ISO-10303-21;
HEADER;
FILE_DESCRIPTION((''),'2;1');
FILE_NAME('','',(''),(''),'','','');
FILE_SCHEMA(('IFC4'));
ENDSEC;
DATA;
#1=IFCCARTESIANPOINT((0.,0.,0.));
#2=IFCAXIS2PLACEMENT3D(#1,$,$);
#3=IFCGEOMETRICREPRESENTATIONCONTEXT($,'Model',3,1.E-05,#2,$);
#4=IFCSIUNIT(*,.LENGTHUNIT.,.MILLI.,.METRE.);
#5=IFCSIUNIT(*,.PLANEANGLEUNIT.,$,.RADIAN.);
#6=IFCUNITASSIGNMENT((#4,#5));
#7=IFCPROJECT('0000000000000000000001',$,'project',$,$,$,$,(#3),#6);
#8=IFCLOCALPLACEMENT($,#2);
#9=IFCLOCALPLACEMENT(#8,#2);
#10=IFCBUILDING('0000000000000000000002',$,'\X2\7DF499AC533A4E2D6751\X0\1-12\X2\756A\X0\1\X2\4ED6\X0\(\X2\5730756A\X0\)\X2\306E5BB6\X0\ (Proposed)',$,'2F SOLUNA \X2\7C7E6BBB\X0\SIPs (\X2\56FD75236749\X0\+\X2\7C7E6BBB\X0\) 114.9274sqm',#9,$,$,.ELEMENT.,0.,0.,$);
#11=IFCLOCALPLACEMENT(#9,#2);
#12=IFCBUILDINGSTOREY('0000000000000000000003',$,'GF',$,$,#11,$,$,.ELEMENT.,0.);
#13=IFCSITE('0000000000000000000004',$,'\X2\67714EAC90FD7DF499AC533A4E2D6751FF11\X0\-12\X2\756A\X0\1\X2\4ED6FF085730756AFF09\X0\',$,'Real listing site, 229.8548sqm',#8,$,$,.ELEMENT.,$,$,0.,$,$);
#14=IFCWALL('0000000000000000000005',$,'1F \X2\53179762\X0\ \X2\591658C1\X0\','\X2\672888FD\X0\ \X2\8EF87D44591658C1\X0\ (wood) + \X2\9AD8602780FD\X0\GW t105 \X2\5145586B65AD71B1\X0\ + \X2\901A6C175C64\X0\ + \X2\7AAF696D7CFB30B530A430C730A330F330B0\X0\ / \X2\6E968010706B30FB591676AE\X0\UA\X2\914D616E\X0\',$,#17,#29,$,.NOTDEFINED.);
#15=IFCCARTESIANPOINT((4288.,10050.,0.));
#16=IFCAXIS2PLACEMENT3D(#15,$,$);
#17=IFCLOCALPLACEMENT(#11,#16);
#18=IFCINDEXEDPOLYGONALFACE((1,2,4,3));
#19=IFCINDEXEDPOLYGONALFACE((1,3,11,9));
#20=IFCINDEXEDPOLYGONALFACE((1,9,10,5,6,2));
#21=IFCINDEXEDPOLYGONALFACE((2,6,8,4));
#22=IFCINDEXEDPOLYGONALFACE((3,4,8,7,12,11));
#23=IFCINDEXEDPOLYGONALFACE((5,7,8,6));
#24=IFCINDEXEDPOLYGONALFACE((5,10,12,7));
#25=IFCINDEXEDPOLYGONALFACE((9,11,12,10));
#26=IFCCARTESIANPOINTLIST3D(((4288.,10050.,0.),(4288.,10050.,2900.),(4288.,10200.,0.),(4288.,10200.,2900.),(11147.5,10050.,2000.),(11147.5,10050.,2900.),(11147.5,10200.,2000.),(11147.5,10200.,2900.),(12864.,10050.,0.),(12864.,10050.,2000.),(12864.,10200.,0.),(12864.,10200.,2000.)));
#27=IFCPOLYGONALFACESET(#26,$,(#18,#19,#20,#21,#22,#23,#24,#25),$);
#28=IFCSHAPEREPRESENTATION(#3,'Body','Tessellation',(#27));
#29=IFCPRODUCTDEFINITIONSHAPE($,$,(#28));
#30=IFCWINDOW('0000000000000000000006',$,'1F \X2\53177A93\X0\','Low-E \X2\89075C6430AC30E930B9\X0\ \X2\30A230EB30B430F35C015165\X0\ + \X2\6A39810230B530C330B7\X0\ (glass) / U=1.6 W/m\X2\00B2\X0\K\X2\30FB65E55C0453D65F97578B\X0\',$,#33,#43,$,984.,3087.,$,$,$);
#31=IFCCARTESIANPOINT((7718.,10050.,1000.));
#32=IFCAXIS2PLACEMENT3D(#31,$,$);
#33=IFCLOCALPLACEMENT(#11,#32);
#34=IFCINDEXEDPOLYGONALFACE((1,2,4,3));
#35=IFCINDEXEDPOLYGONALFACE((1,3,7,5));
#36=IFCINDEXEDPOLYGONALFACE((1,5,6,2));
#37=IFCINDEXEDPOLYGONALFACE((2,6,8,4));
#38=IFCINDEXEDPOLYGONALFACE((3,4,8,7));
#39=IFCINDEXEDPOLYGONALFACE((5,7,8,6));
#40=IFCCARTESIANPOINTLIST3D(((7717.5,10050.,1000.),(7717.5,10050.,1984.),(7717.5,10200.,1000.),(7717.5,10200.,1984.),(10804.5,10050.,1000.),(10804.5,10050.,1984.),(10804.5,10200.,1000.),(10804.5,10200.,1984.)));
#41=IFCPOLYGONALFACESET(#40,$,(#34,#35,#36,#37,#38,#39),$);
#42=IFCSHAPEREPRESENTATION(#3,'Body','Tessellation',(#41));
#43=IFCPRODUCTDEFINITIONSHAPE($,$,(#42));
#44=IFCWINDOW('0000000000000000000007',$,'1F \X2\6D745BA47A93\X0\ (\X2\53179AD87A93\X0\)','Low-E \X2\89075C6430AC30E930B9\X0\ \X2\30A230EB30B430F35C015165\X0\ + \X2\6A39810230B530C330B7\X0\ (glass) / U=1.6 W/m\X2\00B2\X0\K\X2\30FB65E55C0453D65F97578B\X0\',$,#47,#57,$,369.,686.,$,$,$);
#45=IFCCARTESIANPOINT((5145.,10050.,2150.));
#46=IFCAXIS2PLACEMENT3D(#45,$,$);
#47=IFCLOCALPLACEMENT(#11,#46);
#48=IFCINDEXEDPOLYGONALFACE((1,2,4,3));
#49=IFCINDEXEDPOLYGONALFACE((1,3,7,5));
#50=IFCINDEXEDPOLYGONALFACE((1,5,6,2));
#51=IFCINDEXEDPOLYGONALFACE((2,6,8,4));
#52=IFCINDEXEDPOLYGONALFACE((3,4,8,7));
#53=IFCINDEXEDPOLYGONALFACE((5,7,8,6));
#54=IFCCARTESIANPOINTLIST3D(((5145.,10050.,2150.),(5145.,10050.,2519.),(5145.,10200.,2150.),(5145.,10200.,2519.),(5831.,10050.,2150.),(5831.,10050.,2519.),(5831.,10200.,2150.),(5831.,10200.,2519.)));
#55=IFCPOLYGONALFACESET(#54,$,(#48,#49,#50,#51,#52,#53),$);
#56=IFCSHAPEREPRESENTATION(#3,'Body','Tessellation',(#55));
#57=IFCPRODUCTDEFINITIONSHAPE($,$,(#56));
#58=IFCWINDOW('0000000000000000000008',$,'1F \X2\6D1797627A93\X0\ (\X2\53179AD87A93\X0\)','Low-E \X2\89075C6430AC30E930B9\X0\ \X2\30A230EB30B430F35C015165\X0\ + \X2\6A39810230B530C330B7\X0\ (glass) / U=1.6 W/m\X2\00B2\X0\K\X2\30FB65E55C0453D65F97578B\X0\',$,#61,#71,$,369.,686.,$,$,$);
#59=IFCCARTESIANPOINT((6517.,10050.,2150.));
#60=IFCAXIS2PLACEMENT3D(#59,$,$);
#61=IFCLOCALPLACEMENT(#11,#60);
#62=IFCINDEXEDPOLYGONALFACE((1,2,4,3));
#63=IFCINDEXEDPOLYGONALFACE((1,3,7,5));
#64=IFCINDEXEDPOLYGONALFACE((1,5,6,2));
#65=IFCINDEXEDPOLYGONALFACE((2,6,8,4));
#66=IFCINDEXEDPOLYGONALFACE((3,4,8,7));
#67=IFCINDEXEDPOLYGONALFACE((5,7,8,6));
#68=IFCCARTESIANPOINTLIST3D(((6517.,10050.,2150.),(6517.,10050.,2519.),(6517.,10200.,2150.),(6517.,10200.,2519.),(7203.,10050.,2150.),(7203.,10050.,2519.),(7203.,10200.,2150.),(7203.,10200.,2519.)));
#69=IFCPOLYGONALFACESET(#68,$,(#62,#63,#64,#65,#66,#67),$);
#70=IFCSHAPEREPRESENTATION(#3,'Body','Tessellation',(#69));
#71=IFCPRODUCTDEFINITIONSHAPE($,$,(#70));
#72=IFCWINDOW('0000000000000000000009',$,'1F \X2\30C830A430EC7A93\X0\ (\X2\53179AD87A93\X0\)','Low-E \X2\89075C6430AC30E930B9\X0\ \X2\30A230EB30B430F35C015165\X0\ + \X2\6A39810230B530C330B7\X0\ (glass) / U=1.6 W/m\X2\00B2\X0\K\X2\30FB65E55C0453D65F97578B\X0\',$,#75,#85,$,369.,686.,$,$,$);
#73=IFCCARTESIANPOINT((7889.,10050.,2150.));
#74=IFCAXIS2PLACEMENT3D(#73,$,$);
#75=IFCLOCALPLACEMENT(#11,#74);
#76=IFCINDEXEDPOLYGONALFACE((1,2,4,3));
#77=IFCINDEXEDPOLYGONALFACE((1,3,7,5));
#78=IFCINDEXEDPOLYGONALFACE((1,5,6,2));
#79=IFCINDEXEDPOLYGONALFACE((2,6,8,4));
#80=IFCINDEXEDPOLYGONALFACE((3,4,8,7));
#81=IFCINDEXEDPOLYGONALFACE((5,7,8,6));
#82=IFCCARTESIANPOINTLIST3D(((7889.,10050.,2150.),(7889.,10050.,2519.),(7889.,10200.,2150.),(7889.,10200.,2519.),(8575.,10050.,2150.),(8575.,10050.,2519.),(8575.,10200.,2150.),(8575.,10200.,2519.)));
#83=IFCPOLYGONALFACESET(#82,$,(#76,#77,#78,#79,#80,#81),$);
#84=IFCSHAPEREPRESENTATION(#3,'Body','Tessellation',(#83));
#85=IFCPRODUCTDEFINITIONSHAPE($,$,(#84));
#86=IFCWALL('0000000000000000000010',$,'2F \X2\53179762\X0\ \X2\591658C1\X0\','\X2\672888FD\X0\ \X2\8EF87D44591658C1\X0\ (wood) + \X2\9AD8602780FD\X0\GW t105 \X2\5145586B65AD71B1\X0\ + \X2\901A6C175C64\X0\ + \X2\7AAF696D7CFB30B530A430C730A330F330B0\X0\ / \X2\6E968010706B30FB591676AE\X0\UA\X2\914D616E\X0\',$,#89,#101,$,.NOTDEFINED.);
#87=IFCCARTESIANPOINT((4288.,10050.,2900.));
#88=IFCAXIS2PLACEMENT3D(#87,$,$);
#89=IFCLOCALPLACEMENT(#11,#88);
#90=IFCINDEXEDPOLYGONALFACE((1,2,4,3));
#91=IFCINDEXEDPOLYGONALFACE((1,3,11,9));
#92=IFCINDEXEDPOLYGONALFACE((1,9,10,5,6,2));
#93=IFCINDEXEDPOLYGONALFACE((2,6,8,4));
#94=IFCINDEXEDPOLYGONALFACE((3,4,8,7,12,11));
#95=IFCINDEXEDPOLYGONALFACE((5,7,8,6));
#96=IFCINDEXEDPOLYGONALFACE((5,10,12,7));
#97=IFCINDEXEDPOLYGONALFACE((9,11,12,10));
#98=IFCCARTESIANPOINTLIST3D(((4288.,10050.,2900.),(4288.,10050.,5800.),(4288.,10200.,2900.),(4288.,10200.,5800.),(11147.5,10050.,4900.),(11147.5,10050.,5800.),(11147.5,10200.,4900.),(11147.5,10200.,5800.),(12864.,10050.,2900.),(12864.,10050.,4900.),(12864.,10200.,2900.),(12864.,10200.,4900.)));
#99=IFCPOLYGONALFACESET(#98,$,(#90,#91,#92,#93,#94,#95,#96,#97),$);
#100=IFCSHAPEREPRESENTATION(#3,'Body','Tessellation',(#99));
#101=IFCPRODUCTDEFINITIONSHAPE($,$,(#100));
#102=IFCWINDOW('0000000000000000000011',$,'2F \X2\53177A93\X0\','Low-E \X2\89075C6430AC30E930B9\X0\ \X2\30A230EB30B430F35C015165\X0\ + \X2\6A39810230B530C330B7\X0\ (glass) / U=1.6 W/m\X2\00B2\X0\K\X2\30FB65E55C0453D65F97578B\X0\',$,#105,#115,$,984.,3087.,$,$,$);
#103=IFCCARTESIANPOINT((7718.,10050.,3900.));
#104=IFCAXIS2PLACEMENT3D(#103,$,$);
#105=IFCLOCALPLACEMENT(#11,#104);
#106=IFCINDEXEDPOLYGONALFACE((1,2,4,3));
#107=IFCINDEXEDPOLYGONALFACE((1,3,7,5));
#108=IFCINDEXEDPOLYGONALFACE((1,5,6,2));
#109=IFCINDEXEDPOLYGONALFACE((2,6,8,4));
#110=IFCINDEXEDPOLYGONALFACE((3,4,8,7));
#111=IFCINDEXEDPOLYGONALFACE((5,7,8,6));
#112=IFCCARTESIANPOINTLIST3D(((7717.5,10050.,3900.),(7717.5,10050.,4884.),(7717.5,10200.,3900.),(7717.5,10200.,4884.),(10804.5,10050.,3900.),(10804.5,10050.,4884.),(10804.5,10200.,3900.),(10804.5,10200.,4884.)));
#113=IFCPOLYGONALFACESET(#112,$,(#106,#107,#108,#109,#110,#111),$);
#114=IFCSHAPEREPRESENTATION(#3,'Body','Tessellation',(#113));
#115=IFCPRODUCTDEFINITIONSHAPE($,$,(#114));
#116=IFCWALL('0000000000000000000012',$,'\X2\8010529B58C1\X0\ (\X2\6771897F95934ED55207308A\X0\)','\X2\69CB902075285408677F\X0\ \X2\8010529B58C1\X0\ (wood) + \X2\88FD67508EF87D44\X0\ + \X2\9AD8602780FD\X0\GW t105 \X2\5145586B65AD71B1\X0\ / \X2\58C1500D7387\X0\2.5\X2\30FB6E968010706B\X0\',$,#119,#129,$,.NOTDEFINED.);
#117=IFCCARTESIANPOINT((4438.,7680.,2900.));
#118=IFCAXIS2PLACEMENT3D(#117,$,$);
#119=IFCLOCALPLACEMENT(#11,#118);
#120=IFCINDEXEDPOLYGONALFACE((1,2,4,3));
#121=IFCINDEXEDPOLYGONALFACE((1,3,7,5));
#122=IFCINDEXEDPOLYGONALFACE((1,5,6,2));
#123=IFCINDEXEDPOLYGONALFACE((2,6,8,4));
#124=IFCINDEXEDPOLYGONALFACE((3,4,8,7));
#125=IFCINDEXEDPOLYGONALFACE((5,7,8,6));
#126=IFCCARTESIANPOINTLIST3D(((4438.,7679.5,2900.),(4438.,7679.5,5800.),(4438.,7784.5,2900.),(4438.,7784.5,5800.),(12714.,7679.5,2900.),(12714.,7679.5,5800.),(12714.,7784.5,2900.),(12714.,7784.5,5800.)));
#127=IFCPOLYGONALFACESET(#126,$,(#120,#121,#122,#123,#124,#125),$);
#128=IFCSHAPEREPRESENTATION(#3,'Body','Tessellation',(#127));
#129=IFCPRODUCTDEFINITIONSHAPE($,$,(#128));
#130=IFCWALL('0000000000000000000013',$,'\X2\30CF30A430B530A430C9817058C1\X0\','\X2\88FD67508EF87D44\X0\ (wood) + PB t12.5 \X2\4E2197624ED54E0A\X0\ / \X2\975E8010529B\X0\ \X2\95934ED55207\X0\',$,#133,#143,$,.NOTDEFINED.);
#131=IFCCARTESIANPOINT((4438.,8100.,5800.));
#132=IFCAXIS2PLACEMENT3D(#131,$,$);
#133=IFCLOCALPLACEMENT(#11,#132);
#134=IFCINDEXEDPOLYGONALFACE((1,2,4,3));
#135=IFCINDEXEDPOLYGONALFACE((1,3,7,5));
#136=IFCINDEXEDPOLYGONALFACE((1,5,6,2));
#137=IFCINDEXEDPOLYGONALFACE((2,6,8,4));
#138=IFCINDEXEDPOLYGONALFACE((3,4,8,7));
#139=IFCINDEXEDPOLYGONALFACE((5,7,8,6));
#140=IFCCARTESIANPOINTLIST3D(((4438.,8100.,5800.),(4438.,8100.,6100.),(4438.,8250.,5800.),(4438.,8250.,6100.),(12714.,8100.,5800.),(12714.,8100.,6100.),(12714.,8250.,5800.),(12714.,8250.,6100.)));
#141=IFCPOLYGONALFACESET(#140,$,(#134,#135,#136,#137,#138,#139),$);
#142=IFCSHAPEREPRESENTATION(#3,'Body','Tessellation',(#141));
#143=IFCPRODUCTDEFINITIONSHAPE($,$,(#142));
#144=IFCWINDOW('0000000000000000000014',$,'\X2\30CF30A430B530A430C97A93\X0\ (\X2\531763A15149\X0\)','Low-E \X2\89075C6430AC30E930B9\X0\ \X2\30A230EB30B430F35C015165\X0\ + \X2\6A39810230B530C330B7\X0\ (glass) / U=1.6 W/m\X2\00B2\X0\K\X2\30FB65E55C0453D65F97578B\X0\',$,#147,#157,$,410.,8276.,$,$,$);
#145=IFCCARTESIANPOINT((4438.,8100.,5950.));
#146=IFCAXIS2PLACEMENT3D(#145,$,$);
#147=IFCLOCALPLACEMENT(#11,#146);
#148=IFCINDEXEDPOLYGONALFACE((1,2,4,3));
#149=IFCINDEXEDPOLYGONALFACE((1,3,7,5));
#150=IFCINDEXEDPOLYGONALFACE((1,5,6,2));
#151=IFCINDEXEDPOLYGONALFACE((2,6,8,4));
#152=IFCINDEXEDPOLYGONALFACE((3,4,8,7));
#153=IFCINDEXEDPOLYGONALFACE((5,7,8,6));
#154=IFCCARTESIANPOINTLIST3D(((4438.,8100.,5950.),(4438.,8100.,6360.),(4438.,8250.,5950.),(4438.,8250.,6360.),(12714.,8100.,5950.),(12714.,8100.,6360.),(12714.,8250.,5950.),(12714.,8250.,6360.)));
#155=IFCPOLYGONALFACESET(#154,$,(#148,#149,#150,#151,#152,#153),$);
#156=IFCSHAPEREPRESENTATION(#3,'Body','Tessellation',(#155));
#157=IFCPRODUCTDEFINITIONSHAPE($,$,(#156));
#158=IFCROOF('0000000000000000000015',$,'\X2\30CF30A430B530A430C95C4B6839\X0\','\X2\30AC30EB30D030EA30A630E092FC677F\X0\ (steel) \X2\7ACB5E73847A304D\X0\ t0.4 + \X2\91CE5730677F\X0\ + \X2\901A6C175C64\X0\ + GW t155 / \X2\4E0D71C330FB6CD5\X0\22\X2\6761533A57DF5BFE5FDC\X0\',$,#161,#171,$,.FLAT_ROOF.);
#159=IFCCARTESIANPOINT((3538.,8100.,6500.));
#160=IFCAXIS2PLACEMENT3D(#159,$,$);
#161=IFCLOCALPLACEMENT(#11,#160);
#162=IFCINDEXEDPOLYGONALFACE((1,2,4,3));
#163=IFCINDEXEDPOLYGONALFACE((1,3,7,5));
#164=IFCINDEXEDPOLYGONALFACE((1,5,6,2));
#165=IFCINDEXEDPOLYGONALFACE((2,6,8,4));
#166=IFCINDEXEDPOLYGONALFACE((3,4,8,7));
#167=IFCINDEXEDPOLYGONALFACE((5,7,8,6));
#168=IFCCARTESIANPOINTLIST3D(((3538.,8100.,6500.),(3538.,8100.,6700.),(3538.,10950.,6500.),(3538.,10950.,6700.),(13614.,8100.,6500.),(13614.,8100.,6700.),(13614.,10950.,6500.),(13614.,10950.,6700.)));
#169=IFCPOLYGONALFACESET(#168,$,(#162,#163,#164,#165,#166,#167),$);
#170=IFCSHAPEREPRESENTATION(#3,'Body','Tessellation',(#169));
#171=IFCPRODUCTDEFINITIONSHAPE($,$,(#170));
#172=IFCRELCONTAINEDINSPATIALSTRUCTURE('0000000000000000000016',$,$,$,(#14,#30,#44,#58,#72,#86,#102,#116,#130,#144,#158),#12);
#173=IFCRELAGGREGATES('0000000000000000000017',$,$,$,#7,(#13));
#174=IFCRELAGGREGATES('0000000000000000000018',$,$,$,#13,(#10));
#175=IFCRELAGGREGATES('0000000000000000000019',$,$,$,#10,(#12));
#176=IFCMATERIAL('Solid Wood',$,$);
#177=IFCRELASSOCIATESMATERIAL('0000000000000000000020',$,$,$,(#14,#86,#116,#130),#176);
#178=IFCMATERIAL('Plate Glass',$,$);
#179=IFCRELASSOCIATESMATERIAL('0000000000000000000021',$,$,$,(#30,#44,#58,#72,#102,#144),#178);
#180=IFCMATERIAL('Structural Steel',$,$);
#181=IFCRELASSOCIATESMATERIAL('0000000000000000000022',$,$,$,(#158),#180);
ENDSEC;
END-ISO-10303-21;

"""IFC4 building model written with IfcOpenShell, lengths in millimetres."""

from ifc_helpers import new_model, si_unit, frame, frame_2d, origin, place, context, project, spatial, rectangle, extrude, material, element, fill, save


model = new_model("IFC4")

# Units and contexts
model_context = context("Model", 3, precision=1e-05, world=origin())
ifc_project = project(units=[si_unit("LENGTHUNIT", "METRE", prefix="MILLI"), si_unit("PLANEANGLEUNIT", "RADIAN")], contexts=[model_context])

# Site, building, storey
site_placement = place(None, origin())
site = spatial("IfcSite", under=ifc_project, at=site_placement, Name="東京都練馬区中村１-12番1他（地番）", ObjectType="Real listing site, 229.8548sqm", CompositionType="ELEMENT", RefElevation=0.0)
building_placement = place(site_placement, origin())
building = spatial("IfcBuilding", under=site, at=building_placement, Name="練馬区中村1-12番1他(地番)の家 (Proposed)", ObjectType="2F SOLUNA 籾殻SIPs (国産杉+籾殻) 114.9274sqm", CompositionType="ELEMENT", ElevationOfRefHeight=0.0, ElevationOfTerrain=0.0)
storey_placement = place(building_placement, origin())
storey = spatial("IfcBuildingStorey", under=building, at=storey_placement, Name="GF", CompositionType="ELEMENT", Elevation=0.0)

# Wall, openings, windows
ifc_material_1 = material(Name="Solid Wood")
wall_1_placement = place(storey_placement, frame((4288.0, 10050.0, 0.0)))
wall_1 = element("IfcWall", 1, at=wall_1_placement, inside=storey, material=ifc_material_1, Name="1F 北面 外壁", Description="木製 軸組外壁 (wood) + 高性能GW t105 充填断熱 + 通気層 + 窯業系サイディング / 準耐火・外皮UA配慮", PredefinedType="NOTDEFINED", context=model_context, shape_type="SweptSolid", body=[
    extrude(rectangle(XDim=8576.0, YDim=150.0, at=frame_2d((4288.0, 75.0))), frame((4288.0, 10050.0, 0.0)), (0.0, 0.0, 1.0), 2900.0),
])
opening_1_placement = place(storey_placement, frame((7718.0, 10050.0, 1000.0)))
opening_1 = element("IfcOpeningElement", 2, at=opening_1_placement, cuts=wall_1, PredefinedType="NOTDEFINED", context=model_context, shape_type="SweptSolid", body=[
    extrude(rectangle(XDim=3087.0, YDim=150.0, at=frame_2d((1543.0, 75.0))), frame((7718.0, 10050.0, 1000.0)), (0.0, 0.0, 1.0), 984.0),
])
opening_2_placement = place(storey_placement, frame((5145.0, 10050.0, 2150.0)))
opening_2 = element("IfcOpeningElement", 3, at=opening_2_placement, cuts=wall_1, PredefinedType="NOTDEFINED", context=model_context, shape_type="SweptSolid", body=[
    extrude(rectangle(XDim=686.0, YDim=150.0, at=frame_2d((343.0, 75.0))), frame((5145.0, 10050.0, 2150.0)), (0.0, 0.0, 1.0), 369.0),
])
opening_3_placement = place(storey_placement, frame((6517.0, 10050.0, 2150.0)))
opening_3 = element("IfcOpeningElement", 4, at=opening_3_placement, cuts=wall_1, PredefinedType="NOTDEFINED", context=model_context, shape_type="SweptSolid", body=[
    extrude(rectangle(XDim=686.0, YDim=150.0, at=frame_2d((343.0, 75.0))), frame((6517.0, 10050.0, 2150.0)), (0.0, 0.0, 1.0), 369.0),
])
opening_4_placement = place(storey_placement, frame((7889.0, 10050.0, 2150.0)))
opening_4 = element("IfcOpeningElement", 5, at=opening_4_placement, cuts=wall_1, PredefinedType="NOTDEFINED", context=model_context, shape_type="SweptSolid", body=[
    extrude(rectangle(XDim=686.0, YDim=150.0, at=frame_2d((343.0, 75.0))), frame((7889.0, 10050.0, 2150.0)), (0.0, 0.0, 1.0), 369.0),
])
ifc_material_2 = material(Name="Plate Glass")
window_1_placement = place(storey_placement, frame((7718.0, 10050.0, 1000.0)))
window_1 = element("IfcWindow", 6, at=window_1_placement, inside=storey, material=ifc_material_2, Name="1F 北窓", Description="Low-E 複層ガラス アルゴン封入 + 樹脂サッシ (glass) / U=1.6 W/m²K・日射取得型", OverallHeight=984.0, OverallWidth=3087.0, context=model_context, shape_type="SweptSolid", body=[
    extrude(rectangle(XDim=3087.0, YDim=150.0, at=frame_2d((1543.0, 75.0))), frame((7718.0, 10050.0, 1000.0)), (0.0, 0.0, 1.0), 984.0),
])
fill(opening_1, window_1)
window_2_placement = place(storey_placement, frame((5145.0, 10050.0, 2150.0)))
window_2 = element("IfcWindow", 7, at=window_2_placement, inside=storey, material=ifc_material_2, Name="1F 浴室窓 (北高窓)", Description="Low-E 複層ガラス アルゴン封入 + 樹脂サッシ (glass) / U=1.6 W/m²K・日射取得型", OverallHeight=369.0, OverallWidth=686.0, context=model_context, shape_type="SweptSolid", body=[
    extrude(rectangle(XDim=686.0, YDim=150.0, at=frame_2d((343.0, 75.0))), frame((5145.0, 10050.0, 2150.0)), (0.0, 0.0, 1.0), 369.0),
])
fill(opening_2, window_2)
window_3_placement = place(storey_placement, frame((6517.0, 10050.0, 2150.0)))
window_3 = element("IfcWindow", 8, at=window_3_placement, inside=storey, material=ifc_material_2, Name="1F 洗面窓 (北高窓)", Description="Low-E 複層ガラス アルゴン封入 + 樹脂サッシ (glass) / U=1.6 W/m²K・日射取得型", OverallHeight=369.0, OverallWidth=686.0, context=model_context, shape_type="SweptSolid", body=[
    extrude(rectangle(XDim=686.0, YDim=150.0, at=frame_2d((343.0, 75.0))), frame((6517.0, 10050.0, 2150.0)), (0.0, 0.0, 1.0), 369.0),
])
fill(opening_3, window_3)
window_4_placement = place(storey_placement, frame((7889.0, 10050.0, 2150.0)))
window_4 = element("IfcWindow", 9, at=window_4_placement, inside=storey, material=ifc_material_2, Name="1F トイレ窓 (北高窓)", Description="Low-E 複層ガラス アルゴン封入 + 樹脂サッシ (glass) / U=1.6 W/m²K・日射取得型", OverallHeight=369.0, OverallWidth=686.0, context=model_context, shape_type="SweptSolid", body=[
    extrude(rectangle(XDim=686.0, YDim=150.0, at=frame_2d((343.0, 75.0))), frame((7889.0, 10050.0, 2150.0)), (0.0, 0.0, 1.0), 369.0),
])
fill(opening_4, window_4)

# Wall, opening, window
wall_2_placement = place(storey_placement, frame((4288.0, 10050.0, 2900.0)))
wall_2 = element("IfcWall", 10, at=wall_2_placement, inside=storey, material=ifc_material_1, Name="2F 北面 外壁", Description="木製 軸組外壁 (wood) + 高性能GW t105 充填断熱 + 通気層 + 窯業系サイディング / 準耐火・外皮UA配慮", PredefinedType="NOTDEFINED", context=model_context, shape_type="SweptSolid", body=[
    extrude(rectangle(XDim=8576.0, YDim=150.0, at=frame_2d((4288.0, 75.0))), frame((4288.0, 10050.0, 2900.0)), (0.0, 0.0, 1.0), 2900.0),
])
opening_5_placement = place(storey_placement, frame((7718.0, 10050.0, 3900.0)))
opening_5 = element("IfcOpeningElement", 11, at=opening_5_placement, cuts=wall_2, PredefinedType="NOTDEFINED", context=model_context, shape_type="SweptSolid", body=[
    extrude(rectangle(XDim=3087.0, YDim=150.0, at=frame_2d((1543.0, 75.0))), frame((7718.0, 10050.0, 3900.0)), (0.0, 0.0, 1.0), 984.0),
])
window_5_placement = place(storey_placement, frame((7718.0, 10050.0, 3900.0)))
window_5 = element("IfcWindow", 12, at=window_5_placement, inside=storey, material=ifc_material_2, Name="2F 北窓", Description="Low-E 複層ガラス アルゴン封入 + 樹脂サッシ (glass) / U=1.6 W/m²K・日射取得型", OverallHeight=984.0, OverallWidth=3087.0, context=model_context, shape_type="SweptSolid", body=[
    extrude(rectangle(XDim=3087.0, YDim=150.0, at=frame_2d((1543.0, 75.0))), frame((7718.0, 10050.0, 3900.0)), (0.0, 0.0, 1.0), 984.0),
])
fill(opening_5, window_5)

# Wall
wall_3_placement = place(storey_placement, frame((4438.0, 7680.0, 2900.0)))
element("IfcWall", 13, at=wall_3_placement, inside=storey, material=ifc_material_1, Name="耐力壁 (東西間仕切り)", Description="構造用合板 耐力壁 (wood) + 製材軸組 + 高性能GW t105 充填断熱 / 壁倍率2.5・準耐火", PredefinedType="NOTDEFINED", context=model_context, shape_type="SweptSolid", body=[
    extrude(rectangle(XDim=8276.0, YDim=105.0, at=frame_2d((4138.0, 52.0))), frame((4438.0, 7680.0, 2900.0)), (0.0, 0.0, 1.0), 2900.0),
])

# Wall, opening, window
wall_4_placement = place(storey_placement, frame((4438.0, 8100.0, 5800.0)))
wall_4 = element("IfcWall", 14, at=wall_4_placement, inside=storey, material=ifc_material_1, Name="ハイサイド腰壁", Description="製材軸組 (wood) + PB t12.5 両面仕上 / 非耐力 間仕切", PredefinedType="NOTDEFINED", context=model_context, shape_type="SweptSolid", body=[
    extrude(rectangle(XDim=8276.0, YDim=150.0, at=frame_2d((4138.0, 75.0))), frame((4438.0, 8100.0, 5800.0)), (0.0, 0.0, 1.0), 700.0),
])
opening_6_placement = place(storey_placement, frame((4438.0, 8100.0, 5950.0)))
opening_6 = element("IfcOpeningElement", 15, at=opening_6_placement, cuts=wall_4, PredefinedType="NOTDEFINED", context=model_context, shape_type="SweptSolid", body=[
    extrude(rectangle(XDim=8276.0, YDim=150.0, at=frame_2d((4138.0, 75.0))), frame((4438.0, 8100.0, 5950.0)), (0.0, 0.0, 1.0), 410.0),
])
window_6_placement = place(storey_placement, frame((4438.0, 8100.0, 5950.0)))
window_6 = element("IfcWindow", 16, at=window_6_placement, inside=storey, material=ifc_material_2, Name="ハイサイド窓 (北採光)", Description="Low-E 複層ガラス アルゴン封入 + 樹脂サッシ (glass) / U=1.6 W/m²K・日射取得型", OverallHeight=410.0, OverallWidth=8276.0, context=model_context, shape_type="SweptSolid", body=[
    extrude(rectangle(XDim=8276.0, YDim=150.0, at=frame_2d((4138.0, 75.0))), frame((4438.0, 8100.0, 5950.0)), (0.0, 0.0, 1.0), 410.0),
])
fill(opening_6, window_6)

# Roof
ifc_material_3 = material(Name="Structural Steel")
roof_placement = place(storey_placement, frame((3538.0, 8100.0, 6500.0)))
element("IfcRoof", 17, at=roof_placement, inside=storey, material=ifc_material_3, Name="ハイサイド屋根", Description="ガルバリウム鋼板 (steel) 立平葺き t0.4 + 野地板 + 通気層 + GW t155 / 不燃・法22条区域対応", PredefinedType="FLAT_ROOF", context=model_context, shape_type="SweptSolid", body=[
    extrude(rectangle(XDim=10076.0, YDim=2850.0, at=frame_2d((5038.0, 1425.0))), frame((3538.0, 8100.0, 6500.0)), (0.0, 0.0, 1.0), 200.0),
])

save(model, "model.ifc")
